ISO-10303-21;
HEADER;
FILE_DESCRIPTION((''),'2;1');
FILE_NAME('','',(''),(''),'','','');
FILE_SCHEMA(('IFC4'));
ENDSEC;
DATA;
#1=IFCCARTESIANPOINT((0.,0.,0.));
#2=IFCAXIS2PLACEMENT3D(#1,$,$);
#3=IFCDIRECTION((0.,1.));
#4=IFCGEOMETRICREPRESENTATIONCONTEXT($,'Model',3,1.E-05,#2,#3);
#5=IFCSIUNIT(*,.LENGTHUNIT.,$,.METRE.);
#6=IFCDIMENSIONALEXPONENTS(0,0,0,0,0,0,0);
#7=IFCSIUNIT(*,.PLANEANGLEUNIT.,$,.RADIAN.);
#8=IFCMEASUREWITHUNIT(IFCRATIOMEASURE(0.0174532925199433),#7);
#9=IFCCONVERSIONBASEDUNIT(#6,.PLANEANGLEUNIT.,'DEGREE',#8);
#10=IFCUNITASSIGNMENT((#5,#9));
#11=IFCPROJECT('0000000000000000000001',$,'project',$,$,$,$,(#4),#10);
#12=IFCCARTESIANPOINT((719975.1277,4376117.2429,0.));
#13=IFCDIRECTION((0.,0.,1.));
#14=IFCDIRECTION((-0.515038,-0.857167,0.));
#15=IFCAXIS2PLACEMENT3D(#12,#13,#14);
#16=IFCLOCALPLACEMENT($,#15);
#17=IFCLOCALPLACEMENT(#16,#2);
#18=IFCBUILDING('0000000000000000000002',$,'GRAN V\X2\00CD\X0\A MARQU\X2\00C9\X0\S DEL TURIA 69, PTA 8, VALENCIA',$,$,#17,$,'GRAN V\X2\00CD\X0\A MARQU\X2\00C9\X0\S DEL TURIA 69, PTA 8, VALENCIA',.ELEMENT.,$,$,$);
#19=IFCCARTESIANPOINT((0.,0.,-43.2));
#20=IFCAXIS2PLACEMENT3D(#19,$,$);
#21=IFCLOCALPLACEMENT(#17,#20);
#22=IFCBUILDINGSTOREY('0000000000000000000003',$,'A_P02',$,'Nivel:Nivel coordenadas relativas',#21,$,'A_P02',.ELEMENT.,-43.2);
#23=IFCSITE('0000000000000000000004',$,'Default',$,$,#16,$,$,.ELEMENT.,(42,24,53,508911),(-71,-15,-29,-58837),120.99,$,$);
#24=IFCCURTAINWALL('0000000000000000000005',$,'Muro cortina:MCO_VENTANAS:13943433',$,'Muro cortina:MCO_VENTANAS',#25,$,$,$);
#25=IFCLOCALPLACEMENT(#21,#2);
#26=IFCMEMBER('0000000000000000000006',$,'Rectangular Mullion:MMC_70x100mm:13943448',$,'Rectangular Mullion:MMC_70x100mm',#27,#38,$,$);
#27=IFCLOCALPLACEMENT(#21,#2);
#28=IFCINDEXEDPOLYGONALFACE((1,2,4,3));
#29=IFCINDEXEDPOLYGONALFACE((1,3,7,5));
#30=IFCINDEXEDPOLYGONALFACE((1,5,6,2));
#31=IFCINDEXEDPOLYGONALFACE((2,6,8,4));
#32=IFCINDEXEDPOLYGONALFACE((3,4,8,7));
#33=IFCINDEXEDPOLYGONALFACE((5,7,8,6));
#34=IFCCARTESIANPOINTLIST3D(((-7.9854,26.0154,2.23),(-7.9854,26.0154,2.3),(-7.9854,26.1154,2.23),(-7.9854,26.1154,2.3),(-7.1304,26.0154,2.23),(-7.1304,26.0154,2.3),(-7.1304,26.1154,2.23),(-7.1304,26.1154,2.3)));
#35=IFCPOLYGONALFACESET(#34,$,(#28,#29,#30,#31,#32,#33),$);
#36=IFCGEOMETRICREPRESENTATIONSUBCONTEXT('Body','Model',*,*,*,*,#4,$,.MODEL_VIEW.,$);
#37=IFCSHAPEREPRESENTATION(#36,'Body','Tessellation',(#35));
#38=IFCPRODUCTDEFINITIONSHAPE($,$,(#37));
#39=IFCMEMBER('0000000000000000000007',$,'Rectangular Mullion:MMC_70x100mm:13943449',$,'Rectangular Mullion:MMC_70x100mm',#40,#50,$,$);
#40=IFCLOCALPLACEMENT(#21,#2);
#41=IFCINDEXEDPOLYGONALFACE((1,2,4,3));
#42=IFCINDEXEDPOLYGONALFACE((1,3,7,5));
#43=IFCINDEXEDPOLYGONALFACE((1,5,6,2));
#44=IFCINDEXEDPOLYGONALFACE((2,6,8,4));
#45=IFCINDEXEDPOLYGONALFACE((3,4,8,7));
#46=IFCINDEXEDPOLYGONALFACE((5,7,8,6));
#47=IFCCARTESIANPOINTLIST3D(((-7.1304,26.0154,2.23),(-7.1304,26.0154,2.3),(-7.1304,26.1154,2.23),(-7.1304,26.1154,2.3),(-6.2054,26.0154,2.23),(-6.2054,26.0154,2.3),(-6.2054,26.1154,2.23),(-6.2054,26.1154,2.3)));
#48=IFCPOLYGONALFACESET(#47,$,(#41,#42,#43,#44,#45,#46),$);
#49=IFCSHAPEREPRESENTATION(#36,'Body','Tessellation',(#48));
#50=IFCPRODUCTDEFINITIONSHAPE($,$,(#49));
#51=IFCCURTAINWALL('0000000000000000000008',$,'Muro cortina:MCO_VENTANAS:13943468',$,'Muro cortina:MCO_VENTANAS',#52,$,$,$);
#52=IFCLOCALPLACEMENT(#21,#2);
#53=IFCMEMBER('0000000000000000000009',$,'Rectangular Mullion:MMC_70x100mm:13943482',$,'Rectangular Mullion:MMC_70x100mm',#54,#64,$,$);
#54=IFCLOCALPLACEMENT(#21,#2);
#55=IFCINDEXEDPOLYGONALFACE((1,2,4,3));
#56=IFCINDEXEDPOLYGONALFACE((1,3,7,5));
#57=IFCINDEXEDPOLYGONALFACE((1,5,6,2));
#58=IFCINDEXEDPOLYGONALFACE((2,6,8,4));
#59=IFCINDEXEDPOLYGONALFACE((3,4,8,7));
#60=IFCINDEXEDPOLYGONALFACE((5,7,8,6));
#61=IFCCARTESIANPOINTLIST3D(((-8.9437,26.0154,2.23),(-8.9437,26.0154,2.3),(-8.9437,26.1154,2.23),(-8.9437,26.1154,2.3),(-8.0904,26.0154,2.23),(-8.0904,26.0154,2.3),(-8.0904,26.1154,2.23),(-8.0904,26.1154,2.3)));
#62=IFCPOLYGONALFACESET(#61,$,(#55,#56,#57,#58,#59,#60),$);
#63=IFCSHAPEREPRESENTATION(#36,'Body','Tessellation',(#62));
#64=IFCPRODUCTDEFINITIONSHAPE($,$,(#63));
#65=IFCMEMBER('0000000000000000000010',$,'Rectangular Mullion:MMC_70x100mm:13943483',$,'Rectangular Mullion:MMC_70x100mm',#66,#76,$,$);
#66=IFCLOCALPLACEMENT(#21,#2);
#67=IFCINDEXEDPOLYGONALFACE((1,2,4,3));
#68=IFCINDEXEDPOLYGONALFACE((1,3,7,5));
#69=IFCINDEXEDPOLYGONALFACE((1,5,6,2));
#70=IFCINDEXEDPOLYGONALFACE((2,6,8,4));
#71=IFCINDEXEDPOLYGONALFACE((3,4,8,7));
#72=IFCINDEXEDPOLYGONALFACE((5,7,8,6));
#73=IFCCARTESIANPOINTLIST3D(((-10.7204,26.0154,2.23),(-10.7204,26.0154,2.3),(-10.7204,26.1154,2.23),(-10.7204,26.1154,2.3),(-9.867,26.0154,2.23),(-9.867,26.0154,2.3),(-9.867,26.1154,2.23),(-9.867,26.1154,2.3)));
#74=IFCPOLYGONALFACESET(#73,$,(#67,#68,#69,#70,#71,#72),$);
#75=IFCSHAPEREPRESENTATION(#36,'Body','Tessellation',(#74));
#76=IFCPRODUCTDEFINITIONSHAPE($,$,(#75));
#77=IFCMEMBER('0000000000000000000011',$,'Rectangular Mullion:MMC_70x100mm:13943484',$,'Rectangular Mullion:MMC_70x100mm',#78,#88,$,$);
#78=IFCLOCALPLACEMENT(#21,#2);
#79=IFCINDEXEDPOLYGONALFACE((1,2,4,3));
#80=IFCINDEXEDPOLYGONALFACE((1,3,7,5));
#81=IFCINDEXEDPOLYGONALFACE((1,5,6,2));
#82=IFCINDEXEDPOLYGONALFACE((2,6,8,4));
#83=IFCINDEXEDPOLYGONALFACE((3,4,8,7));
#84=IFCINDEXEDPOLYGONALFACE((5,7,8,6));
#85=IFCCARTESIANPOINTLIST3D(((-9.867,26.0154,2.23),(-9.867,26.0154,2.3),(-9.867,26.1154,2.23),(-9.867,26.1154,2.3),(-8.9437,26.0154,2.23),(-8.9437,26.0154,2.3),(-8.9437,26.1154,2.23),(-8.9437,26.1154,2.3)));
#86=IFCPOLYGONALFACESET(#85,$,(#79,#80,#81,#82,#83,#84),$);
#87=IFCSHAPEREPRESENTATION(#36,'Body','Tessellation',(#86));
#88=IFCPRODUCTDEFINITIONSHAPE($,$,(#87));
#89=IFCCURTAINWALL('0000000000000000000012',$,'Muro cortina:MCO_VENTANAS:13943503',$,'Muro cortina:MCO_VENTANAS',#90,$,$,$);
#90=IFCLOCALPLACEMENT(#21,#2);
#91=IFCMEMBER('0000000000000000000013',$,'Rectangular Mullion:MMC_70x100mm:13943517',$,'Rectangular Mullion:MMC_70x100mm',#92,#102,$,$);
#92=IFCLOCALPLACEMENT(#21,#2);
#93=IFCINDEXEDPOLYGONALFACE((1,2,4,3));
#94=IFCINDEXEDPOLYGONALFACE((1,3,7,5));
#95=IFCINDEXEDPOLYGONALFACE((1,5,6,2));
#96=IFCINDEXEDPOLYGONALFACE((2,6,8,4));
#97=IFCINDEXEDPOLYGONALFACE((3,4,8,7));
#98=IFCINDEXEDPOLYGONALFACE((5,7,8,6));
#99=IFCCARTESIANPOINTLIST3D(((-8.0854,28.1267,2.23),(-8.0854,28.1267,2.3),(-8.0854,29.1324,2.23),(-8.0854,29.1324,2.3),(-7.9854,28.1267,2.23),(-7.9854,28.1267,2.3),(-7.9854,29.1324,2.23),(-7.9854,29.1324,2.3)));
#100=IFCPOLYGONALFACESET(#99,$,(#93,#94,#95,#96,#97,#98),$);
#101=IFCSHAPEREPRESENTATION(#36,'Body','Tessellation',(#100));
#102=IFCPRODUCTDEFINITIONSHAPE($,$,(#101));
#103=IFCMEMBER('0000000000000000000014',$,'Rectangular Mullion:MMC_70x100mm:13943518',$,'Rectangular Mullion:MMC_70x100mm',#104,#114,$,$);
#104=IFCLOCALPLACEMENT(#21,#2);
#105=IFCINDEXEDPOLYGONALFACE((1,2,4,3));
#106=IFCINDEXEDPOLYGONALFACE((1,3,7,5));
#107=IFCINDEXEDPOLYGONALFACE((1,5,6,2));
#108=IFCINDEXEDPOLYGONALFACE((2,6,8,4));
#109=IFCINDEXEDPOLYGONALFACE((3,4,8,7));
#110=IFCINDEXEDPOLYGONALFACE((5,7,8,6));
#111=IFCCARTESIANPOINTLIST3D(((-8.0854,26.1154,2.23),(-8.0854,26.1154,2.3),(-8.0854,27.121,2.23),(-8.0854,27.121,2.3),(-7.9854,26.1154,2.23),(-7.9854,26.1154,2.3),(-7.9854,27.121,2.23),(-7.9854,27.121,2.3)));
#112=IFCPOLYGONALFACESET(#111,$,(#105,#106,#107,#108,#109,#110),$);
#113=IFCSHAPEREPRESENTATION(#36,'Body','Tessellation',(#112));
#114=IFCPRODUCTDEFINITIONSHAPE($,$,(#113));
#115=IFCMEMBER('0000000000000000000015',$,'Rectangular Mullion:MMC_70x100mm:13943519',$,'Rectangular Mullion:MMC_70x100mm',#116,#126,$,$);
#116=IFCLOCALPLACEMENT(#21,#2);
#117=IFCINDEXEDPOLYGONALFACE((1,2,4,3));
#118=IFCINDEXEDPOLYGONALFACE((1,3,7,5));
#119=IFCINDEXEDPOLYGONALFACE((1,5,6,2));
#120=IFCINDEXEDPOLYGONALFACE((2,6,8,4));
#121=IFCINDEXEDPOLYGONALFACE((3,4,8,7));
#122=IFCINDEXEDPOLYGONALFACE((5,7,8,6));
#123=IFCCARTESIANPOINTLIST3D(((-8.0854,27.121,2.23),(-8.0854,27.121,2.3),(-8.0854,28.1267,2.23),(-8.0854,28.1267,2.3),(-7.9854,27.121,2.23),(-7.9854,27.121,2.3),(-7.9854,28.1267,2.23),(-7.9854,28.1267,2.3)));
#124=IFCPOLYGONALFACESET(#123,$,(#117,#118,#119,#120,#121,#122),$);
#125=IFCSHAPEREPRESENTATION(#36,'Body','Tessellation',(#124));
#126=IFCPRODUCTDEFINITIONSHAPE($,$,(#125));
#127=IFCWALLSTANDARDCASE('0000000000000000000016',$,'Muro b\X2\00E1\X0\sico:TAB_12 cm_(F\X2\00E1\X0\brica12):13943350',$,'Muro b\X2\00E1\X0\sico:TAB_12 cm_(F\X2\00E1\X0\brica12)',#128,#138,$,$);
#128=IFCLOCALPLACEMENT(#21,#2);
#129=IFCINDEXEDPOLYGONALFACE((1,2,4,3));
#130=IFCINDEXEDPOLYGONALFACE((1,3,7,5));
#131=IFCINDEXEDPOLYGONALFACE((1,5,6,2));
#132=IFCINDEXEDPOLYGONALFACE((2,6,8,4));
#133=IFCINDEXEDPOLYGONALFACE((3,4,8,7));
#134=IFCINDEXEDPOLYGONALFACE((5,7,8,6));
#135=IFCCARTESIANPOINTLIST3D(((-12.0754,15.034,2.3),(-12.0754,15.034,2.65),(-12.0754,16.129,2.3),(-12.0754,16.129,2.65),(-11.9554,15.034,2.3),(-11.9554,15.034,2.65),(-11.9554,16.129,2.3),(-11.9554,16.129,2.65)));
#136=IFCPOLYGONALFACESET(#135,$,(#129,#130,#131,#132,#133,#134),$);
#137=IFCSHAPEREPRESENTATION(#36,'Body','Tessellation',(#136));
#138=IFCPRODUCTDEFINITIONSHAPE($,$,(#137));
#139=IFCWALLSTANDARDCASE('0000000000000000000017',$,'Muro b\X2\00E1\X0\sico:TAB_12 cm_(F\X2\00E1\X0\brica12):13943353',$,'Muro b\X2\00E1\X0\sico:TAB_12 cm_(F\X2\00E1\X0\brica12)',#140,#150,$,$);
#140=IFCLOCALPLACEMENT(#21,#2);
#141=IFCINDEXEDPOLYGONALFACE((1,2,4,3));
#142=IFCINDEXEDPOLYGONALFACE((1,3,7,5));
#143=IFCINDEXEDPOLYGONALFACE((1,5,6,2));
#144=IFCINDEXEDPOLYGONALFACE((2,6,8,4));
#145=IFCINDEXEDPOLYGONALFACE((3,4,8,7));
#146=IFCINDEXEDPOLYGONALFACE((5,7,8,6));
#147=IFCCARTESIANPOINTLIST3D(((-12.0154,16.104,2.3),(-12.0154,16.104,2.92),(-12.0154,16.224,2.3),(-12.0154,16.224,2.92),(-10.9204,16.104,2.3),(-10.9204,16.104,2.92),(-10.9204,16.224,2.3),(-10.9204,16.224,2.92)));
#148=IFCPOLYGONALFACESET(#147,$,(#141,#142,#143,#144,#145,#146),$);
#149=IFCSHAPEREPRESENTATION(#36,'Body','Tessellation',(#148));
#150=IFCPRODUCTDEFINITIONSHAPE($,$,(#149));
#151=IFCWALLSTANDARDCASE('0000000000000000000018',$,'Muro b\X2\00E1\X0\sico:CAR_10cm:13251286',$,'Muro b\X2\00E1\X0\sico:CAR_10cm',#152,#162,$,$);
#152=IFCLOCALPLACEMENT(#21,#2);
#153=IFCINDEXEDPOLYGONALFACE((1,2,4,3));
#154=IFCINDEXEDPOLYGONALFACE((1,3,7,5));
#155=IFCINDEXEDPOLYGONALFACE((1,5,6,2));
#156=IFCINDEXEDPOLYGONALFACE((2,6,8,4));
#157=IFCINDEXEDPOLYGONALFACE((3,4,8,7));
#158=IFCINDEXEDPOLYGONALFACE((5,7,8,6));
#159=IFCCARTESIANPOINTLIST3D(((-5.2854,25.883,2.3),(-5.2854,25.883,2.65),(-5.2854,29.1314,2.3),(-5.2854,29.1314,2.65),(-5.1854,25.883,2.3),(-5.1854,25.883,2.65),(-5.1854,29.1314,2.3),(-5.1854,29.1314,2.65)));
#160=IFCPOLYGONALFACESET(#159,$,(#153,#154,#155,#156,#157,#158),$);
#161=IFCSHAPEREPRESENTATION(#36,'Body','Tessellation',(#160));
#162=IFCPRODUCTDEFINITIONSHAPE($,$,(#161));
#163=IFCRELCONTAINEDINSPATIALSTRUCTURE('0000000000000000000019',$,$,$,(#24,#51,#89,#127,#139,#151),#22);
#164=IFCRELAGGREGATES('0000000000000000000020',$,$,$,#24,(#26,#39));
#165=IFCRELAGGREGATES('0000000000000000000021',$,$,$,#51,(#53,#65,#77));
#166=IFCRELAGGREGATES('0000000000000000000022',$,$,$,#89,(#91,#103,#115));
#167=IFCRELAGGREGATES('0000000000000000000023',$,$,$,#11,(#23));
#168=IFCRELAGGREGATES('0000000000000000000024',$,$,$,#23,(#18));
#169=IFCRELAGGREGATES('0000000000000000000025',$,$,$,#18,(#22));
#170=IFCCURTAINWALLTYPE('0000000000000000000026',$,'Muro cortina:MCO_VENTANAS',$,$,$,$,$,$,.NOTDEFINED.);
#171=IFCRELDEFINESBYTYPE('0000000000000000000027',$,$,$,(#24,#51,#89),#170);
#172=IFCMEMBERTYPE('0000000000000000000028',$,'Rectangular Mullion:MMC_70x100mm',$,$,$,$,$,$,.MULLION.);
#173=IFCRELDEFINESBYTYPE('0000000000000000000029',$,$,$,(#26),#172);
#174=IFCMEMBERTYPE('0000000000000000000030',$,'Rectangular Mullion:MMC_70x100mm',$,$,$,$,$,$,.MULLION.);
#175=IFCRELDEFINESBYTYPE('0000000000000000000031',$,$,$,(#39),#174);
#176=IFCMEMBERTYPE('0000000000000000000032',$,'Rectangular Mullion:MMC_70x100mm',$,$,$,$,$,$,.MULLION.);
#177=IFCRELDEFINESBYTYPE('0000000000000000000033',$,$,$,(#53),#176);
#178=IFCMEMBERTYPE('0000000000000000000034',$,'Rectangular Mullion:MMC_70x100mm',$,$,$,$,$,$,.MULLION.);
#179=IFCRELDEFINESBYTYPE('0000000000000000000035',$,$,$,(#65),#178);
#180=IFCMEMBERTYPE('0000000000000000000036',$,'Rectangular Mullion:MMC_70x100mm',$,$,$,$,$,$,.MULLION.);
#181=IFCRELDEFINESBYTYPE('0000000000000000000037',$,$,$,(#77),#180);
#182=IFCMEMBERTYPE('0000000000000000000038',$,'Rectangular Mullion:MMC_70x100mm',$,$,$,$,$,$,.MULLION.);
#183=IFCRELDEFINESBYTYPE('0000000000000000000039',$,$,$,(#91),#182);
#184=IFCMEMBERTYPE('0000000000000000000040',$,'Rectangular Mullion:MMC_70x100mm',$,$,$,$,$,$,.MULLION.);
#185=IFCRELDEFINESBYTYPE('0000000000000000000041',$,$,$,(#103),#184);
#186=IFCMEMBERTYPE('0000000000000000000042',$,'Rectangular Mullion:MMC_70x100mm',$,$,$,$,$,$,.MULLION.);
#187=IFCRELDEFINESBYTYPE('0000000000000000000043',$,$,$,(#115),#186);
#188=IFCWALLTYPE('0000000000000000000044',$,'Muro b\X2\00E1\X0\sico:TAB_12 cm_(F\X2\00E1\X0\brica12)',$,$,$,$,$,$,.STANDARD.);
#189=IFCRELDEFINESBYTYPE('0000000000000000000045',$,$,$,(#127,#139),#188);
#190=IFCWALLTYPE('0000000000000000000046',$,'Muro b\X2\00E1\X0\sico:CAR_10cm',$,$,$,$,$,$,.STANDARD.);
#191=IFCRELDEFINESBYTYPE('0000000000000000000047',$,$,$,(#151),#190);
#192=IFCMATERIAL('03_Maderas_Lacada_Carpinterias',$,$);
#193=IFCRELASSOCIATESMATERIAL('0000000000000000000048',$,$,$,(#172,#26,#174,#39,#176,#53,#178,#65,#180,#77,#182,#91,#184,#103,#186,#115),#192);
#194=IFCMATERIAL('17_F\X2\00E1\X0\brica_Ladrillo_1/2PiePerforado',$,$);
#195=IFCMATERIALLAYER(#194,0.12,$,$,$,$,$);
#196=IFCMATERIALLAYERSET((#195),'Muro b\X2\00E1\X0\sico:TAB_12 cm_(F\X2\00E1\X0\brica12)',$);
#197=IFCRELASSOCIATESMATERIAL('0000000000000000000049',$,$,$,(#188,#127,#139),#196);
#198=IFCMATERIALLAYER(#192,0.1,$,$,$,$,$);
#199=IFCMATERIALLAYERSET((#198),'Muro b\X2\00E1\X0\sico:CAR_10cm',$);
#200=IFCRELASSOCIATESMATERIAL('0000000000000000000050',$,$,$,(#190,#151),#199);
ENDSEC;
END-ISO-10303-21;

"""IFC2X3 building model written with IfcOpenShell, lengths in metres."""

from ifc_helpers import new_model, entity, si_unit, converted_unit, direction, frame, frame_2d, origin, origin_2d_with_axis, place, context, subcontext, project, spatial, rectangle, extrude, source, transform, mapped, material, layer, layer_set, layer_usage, type_object, type_shapes, element, aggregate, save


model = new_model("IFC2X3")

# Units and contexts
model_context = context("Model", 3, precision=1e-05, world=origin(), true_north=direction((0.0, 1.0)))
body_context = subcontext(model_context, "Body", "Model", "MODEL_VIEW")
ifc_project = project(units=[si_unit("LENGTHUNIT", "METRE"), converted_unit("PLANEANGLEUNIT", "DEGREE", entity("IfcRatioMeasure", 0.0174532925199433), si_unit("PLANEANGLEUNIT", "RADIAN"), dimensions=[0, 0, 0, 0, 0, 0, 0])], contexts=[model_context])

# Site, building, storey
site_placement = place(None, frame((719975.1277, 4376117.2429, 0.0), z_axis=(0.0, 0.0, 1.0), x_axis=(-0.515038, -0.857167, 0.0)))
site = spatial("IfcSite", under=ifc_project, at=site_placement, Name="Default", CompositionType="ELEMENT", RefLatitude=(42, 24, 53, 508911), RefLongitude=(-71, -15, -29, -58837), RefElevation=120.99)
building_placement = place(site_placement, origin())
building = spatial("IfcBuilding", under=site, at=building_placement, Name="GRAN VÍA MARQUÉS DEL TURIA 69, PTA 8, VALENCIA", LongName="GRAN VÍA MARQUÉS DEL TURIA 69, PTA 8, VALENCIA", CompositionType="ELEMENT")
storey_placement = place(building_placement, frame((0.0, 0.0, -43.2)))
storey = spatial("IfcBuildingStorey", under=building, at=storey_placement, Name="A_P02", ObjectType="Nivel:Nivel coordenadas relativas", LongName="A_P02", CompositionType="ELEMENT", Elevation=-43.2)

# Shared definitions
curtain_wall_type = type_object("IfcCurtainWallType", Name="Muro cortina:MCO_VENTANAS", PredefinedType="NOTDEFINED")
ifc_material_1 = material(Name="03_Maderas_Lacada_Carpinterias")

# Curtain walls, members
curtain_wall_1_placement = place(storey_placement, frame((0.0, 0.0, 43.2)))
curtain_wall_1 = element("IfcCurtainWall", 1, at=curtain_wall_1_placement, inside=storey, type_object=curtain_wall_type, Name="Muro cortina:MCO_VENTANAS:13943433", ObjectType="Muro cortina:MCO_VENTANAS")
member_type_1 = type_object("IfcMemberType", Name="Rectangular Mullion:MMC_70x100mm", PredefinedType="MULLION", material=ifc_material_1)
shared_shape_1 = source(origin(), body_context, "Body", "SweptSolid", [
    extrude(rectangle(XDim=0.1, YDim=0.07, at=origin_2d_with_axis()), frame((-0.035, 0.0, -0.855), z_axis=(0.0, 0.0, 1.0), x_axis=(0.0, -1.0, 0.0)), (0.0, 0.0, 1.0), 0.855),
])
type_shapes(member_type_1, [shared_shape_1])
member_1_placement = place(storey_placement, frame((-7.1304, 26.0654, 2.3), z_axis=(1.0, 0.0, 0.0), x_axis=(0.0, 0.0, 1.0)))
member_1 = element("IfcMember", 2, at=member_1_placement, type_object=member_type_1, material=ifc_material_1, Name="Rectangular Mullion:MMC_70x100mm:13943448", ObjectType="Rectangular Mullion:MMC_70x100mm", context=body_context, shape_type="MappedRepresentation", body=[
    mapped(shared_shape_1, transform((0.0, 0.0, 0.0), scale=1.0)),
])
member_type_2 = type_object("IfcMemberType", Name="Rectangular Mullion:MMC_70x100mm", PredefinedType="MULLION", material=ifc_material_1)
shared_shape_2 = source(origin(), body_context, "Body", "SweptSolid", [
    extrude(rectangle(XDim=0.1, YDim=0.07, at=origin_2d_with_axis()), frame((-0.035, 0.0, -0.925), z_axis=(0.0, 0.0, 1.0), x_axis=(0.0, -1.0, 0.0)), (0.0, 0.0, 1.0), 0.925),
])
type_shapes(member_type_2, [shared_shape_2])
member_2_placement = place(storey_placement, frame((-6.2054, 26.0654, 2.3), z_axis=(1.0, 0.0, 0.0), x_axis=(0.0, 0.0, 1.0)))
member_2 = element("IfcMember", 3, at=member_2_placement, type_object=member_type_2, material=ifc_material_1, Name="Rectangular Mullion:MMC_70x100mm:13943449", ObjectType="Rectangular Mullion:MMC_70x100mm", context=body_context, shape_type="MappedRepresentation", body=[
    mapped(shared_shape_2, transform((0.0, 0.0, 0.0), scale=1.0)),
])
aggregate(curtain_wall_1, [member_1, member_2])
curtain_wall_2_placement = place(storey_placement, frame((0.0, 0.0, 43.2)))
curtain_wall_2 = element("IfcCurtainWall", 4, at=curtain_wall_2_placement, inside=storey, type_object=curtain_wall_type, Name="Muro cortina:MCO_VENTANAS:13943468", ObjectType="Muro cortina:MCO_VENTANAS")
member_type_3 = type_object("IfcMemberType", Name="Rectangular Mullion:MMC_70x100mm", PredefinedType="MULLION", material=ifc_material_1)
shared_shape_3 = source(origin(), body_context, "Body", "SweptSolid", [
    extrude(rectangle(XDim=0.1, YDim=0.07, at=origin_2d_with_axis()), frame((-0.035, 0.0, -0.8533), z_axis=(0.0, 0.0, 1.0), x_axis=(0.0, -1.0, 0.0)), (0.0, 0.0, 1.0), 0.8533),
])
type_shapes(member_type_3, [shared_shape_3])
member_3_placement = place(storey_placement, frame((-8.0904, 26.0654, 2.3), z_axis=(1.0, 0.0, 0.0), x_axis=(0.0, 0.0, 1.0)))
member_3 = element("IfcMember", 5, at=member_3_placement, type_object=member_type_3, material=ifc_material_1, Name="Rectangular Mullion:MMC_70x100mm:13943482", ObjectType="Rectangular Mullion:MMC_70x100mm", context=body_context, shape_type="MappedRepresentation", body=[
    mapped(shared_shape_3, transform((0.0, 0.0, 0.0), scale=1.0)),
])
member_type_4 = type_object("IfcMemberType", Name="Rectangular Mullion:MMC_70x100mm", PredefinedType="MULLION", material=ifc_material_1)
shared_shape_4 = source(origin(), body_context, "Body", "SweptSolid", [
    extrude(rectangle(XDim=0.1, YDim=0.07, at=origin_2d_with_axis()), frame((-0.035, 0.0, -0.8533), z_axis=(0.0, 0.0, 1.0), x_axis=(0.0, -1.0, 0.0)), (0.0, 0.0, 1.0), 0.8533),
])
type_shapes(member_type_4, [shared_shape_4])
member_4_placement = place(storey_placement, frame((-9.867, 26.0654, 2.3), z_axis=(1.0, 0.0, 0.0), x_axis=(0.0, 0.0, 1.0)))
member_4 = element("IfcMember", 6, at=member_4_placement, type_object=member_type_4, material=ifc_material_1, Name="Rectangular Mullion:MMC_70x100mm:13943483", ObjectType="Rectangular Mullion:MMC_70x100mm", context=body_context, shape_type="MappedRepresentation", body=[
    mapped(shared_shape_4, transform((0.0, 0.0, 0.0), scale=1.0)),
])
member_type_5 = type_object("IfcMemberType", Name="Rectangular Mullion:MMC_70x100mm", PredefinedType="MULLION", material=ifc_material_1)
shared_shape_5 = source(origin(), body_context, "Body", "SweptSolid", [
    extrude(rectangle(XDim=0.1, YDim=0.07, at=origin_2d_with_axis()), frame((-0.035, 0.0, -0.9233), z_axis=(0.0, 0.0, 1.0), x_axis=(0.0, -1.0, 0.0)), (0.0, 0.0, 1.0), 0.9233),
])
type_shapes(member_type_5, [shared_shape_5])
member_5_placement = place(storey_placement, frame((-8.9437, 26.0654, 2.3), z_axis=(1.0, 0.0, 0.0), x_axis=(0.0, 0.0, 1.0)))
member_5 = element("IfcMember", 7, at=member_5_placement, type_object=member_type_5, material=ifc_material_1, Name="Rectangular Mullion:MMC_70x100mm:13943484", ObjectType="Rectangular Mullion:MMC_70x100mm", context=body_context, shape_type="MappedRepresentation", body=[
    mapped(shared_shape_5, transform((0.0, 0.0, 0.0), scale=1.0)),
])
aggregate(curtain_wall_2, [member_3, member_4, member_5])
curtain_wall_3_placement = place(storey_placement, frame((0.0, 0.0, 43.2)))
curtain_wall_3 = element("IfcCurtainWall", 8, at=curtain_wall_3_placement, inside=storey, type_object=curtain_wall_type, Name="Muro cortina:MCO_VENTANAS:13943503", ObjectType="Muro cortina:MCO_VENTANAS")
member_type_6 = type_object("IfcMemberType", Name="Rectangular Mullion:MMC_70x100mm", PredefinedType="MULLION", material=ifc_material_1)
shared_shape_6 = source(origin(), body_context, "Body", "SweptSolid", [
    extrude(rectangle(XDim=0.1, YDim=0.07, at=origin_2d_with_axis()), frame((-0.035, 0.0, -1.0057), z_axis=(0.0, 0.0, 1.0), x_axis=(0.0, -1.0, 0.0)), (0.0, 0.0, 1.0), 1.0057),
])
type_shapes(member_type_6, [shared_shape_6])
member_6_placement = place(storey_placement, frame((-8.0354, 29.1324, 2.3), z_axis=(0.0, 1.0, 0.0), x_axis=(0.0, 0.0, 1.0)))
member_6 = element("IfcMember", 9, at=member_6_placement, type_object=member_type_6, material=ifc_material_1, Name="Rectangular Mullion:MMC_70x100mm:13943517", ObjectType="Rectangular Mullion:MMC_70x100mm", context=body_context, shape_type="MappedRepresentation", body=[
    mapped(shared_shape_6, transform((0.0, 0.0, 0.0), scale=1.0)),
])
member_type_7 = type_object("IfcMemberType", Name="Rectangular Mullion:MMC_70x100mm", PredefinedType="MULLION", material=ifc_material_1)
shared_shape_7 = source(origin(), body_context, "Body", "SweptSolid", [
    extrude(rectangle(XDim=0.1, YDim=0.07, at=origin_2d_with_axis()), frame((-0.035, 0.0, -1.0057), z_axis=(0.0, 0.0, 1.0), x_axis=(0.0, -1.0, 0.0)), (0.0, 0.0, 1.0), 1.0057),
])
type_shapes(member_type_7, [shared_shape_7])
member_7_placement = place(storey_placement, frame((-8.0354, 27.121, 2.3), z_axis=(0.0, 1.0, 0.0), x_axis=(0.0, 0.0, 1.0)))
member_7 = element("IfcMember", 10, at=member_7_placement, type_object=member_type_7, material=ifc_material_1, Name="Rectangular Mullion:MMC_70x100mm:13943518", ObjectType="Rectangular Mullion:MMC_70x100mm", context=body_context, shape_type="MappedRepresentation", body=[
    mapped(shared_shape_7, transform((0.0, 0.0, 0.0), scale=1.0)),
])
member_type_8 = type_object("IfcMemberType", Name="Rectangular Mullion:MMC_70x100mm", PredefinedType="MULLION", material=ifc_material_1)
shared_shape_8 = source(origin(), body_context, "Body", "SweptSolid", [
    extrude(rectangle(XDim=0.1, YDim=0.07, at=origin_2d_with_axis()), frame((-0.035, 0.0, -1.0057), z_axis=(0.0, 0.0, 1.0), x_axis=(0.0, -1.0, 0.0)), (0.0, 0.0, 1.0), 1.0057),
])
type_shapes(member_type_8, [shared_shape_8])
member_8_placement = place(storey_placement, frame((-8.0354, 28.1267, 2.3), z_axis=(0.0, 1.0, 0.0), x_axis=(0.0, 0.0, 1.0)))
member_8 = element("IfcMember", 11, at=member_8_placement, type_object=member_type_8, material=ifc_material_1, Name="Rectangular Mullion:MMC_70x100mm:13943519", ObjectType="Rectangular Mullion:MMC_70x100mm", context=body_context, shape_type="MappedRepresentation", body=[
    mapped(shared_shape_8, transform((0.0, 0.0, 0.0), scale=1.0)),
])
aggregate(curtain_wall_3, [member_6, member_7, member_8])

# Walls
ifc_material_2 = material(Name="17_Fábrica_Ladrillo_1/2PiePerforado")
ifc_layer_1 = layer(ifc_material_2, 0.12)
ifc_layer_set_1 = layer_set([ifc_layer_1], Name="Muro básico:TAB_12 cm_(Fábrica12)")
ifc_layer_usage_1 = layer_usage(ifc_layer_set_1, "AXIS2", "POSITIVE", -0.06)
wall_type_1 = type_object("IfcWallType", Name="Muro básico:TAB_12 cm_(Fábrica12)", PredefinedType="STANDARD", material=ifc_layer_set_1)
wall_1_placement = place(storey_placement, frame((-12.0154, 15.034, 2.3), z_axis=(0.0, 0.0, 1.0), x_axis=(0.0, 1.0, 0.0)))
element("IfcWallStandardCase", 12, at=wall_1_placement, inside=storey, type_object=wall_type_1, material=ifc_layer_usage_1, Name="Muro básico:TAB_12 cm_(Fábrica12):13943350", ObjectType="Muro básico:TAB_12 cm_(Fábrica12)", context=body_context, shape_type="SweptSolid", body=[
    extrude(rectangle(XDim=1.095, YDim=0.12, at=frame_2d((0.5475, 0.0), x_axis=(-1.0, 0.0))), origin(), (0.0, 0.0, 1.0), 0.35),
])
ifc_layer_usage_2 = layer_usage(ifc_layer_set_1, "AXIS2", "NEGATIVE", 0.06)
wall_2_placement = place(storey_placement, frame((-10.9204, 16.164, 2.3), z_axis=(0.0, 0.0, 1.0), x_axis=(-1.0, 0.0, 0.0)))
element("IfcWallStandardCase", 13, at=wall_2_placement, inside=storey, type_object=wall_type_1, material=ifc_layer_usage_2, Name="Muro básico:TAB_12 cm_(Fábrica12):13943353", ObjectType="Muro básico:TAB_12 cm_(Fábrica12)", context=body_context, shape_type="SweptSolid", body=[
    extrude(rectangle(XDim=1.095, YDim=0.12, at=frame_2d((0.5475, 0.0), x_axis=(-1.0, 0.0))), origin(), (0.0, 0.0, 1.0), 0.62),
])
ifc_layer_2 = layer(ifc_material_1, 0.1)
ifc_layer_set_2 = layer_set([ifc_layer_2], Name="Muro básico:CAR_10cm")
ifc_layer_usage_3 = layer_usage(ifc_layer_set_2, "AXIS2", "NEGATIVE", 0.05)
wall_type_2 = type_object("IfcWallType", Name="Muro básico:CAR_10cm", PredefinedType="STANDARD", material=ifc_layer_set_2)
wall_3_placement = place(storey_placement, frame((-5.2354, 25.883, 2.3), z_axis=(0.0, 0.0, 1.0), x_axis=(0.0, 1.0, 0.0)))
element("IfcWallStandardCase", 14, at=wall_3_placement, inside=storey, type_object=wall_type_2, material=ifc_layer_usage_3, Name="Muro básico:CAR_10cm:13251286", ObjectType="Muro básico:CAR_10cm", context=body_context, shape_type="SweptSolid", body=[
    extrude(rectangle(XDim=3.2484, YDim=0.1, at=frame_2d((1.6242, 0.0), x_axis=(-1.0, 0.0))), origin(), (0.0, 0.0, 1.0), 0.35),
])

save(model, "model.ifc")
